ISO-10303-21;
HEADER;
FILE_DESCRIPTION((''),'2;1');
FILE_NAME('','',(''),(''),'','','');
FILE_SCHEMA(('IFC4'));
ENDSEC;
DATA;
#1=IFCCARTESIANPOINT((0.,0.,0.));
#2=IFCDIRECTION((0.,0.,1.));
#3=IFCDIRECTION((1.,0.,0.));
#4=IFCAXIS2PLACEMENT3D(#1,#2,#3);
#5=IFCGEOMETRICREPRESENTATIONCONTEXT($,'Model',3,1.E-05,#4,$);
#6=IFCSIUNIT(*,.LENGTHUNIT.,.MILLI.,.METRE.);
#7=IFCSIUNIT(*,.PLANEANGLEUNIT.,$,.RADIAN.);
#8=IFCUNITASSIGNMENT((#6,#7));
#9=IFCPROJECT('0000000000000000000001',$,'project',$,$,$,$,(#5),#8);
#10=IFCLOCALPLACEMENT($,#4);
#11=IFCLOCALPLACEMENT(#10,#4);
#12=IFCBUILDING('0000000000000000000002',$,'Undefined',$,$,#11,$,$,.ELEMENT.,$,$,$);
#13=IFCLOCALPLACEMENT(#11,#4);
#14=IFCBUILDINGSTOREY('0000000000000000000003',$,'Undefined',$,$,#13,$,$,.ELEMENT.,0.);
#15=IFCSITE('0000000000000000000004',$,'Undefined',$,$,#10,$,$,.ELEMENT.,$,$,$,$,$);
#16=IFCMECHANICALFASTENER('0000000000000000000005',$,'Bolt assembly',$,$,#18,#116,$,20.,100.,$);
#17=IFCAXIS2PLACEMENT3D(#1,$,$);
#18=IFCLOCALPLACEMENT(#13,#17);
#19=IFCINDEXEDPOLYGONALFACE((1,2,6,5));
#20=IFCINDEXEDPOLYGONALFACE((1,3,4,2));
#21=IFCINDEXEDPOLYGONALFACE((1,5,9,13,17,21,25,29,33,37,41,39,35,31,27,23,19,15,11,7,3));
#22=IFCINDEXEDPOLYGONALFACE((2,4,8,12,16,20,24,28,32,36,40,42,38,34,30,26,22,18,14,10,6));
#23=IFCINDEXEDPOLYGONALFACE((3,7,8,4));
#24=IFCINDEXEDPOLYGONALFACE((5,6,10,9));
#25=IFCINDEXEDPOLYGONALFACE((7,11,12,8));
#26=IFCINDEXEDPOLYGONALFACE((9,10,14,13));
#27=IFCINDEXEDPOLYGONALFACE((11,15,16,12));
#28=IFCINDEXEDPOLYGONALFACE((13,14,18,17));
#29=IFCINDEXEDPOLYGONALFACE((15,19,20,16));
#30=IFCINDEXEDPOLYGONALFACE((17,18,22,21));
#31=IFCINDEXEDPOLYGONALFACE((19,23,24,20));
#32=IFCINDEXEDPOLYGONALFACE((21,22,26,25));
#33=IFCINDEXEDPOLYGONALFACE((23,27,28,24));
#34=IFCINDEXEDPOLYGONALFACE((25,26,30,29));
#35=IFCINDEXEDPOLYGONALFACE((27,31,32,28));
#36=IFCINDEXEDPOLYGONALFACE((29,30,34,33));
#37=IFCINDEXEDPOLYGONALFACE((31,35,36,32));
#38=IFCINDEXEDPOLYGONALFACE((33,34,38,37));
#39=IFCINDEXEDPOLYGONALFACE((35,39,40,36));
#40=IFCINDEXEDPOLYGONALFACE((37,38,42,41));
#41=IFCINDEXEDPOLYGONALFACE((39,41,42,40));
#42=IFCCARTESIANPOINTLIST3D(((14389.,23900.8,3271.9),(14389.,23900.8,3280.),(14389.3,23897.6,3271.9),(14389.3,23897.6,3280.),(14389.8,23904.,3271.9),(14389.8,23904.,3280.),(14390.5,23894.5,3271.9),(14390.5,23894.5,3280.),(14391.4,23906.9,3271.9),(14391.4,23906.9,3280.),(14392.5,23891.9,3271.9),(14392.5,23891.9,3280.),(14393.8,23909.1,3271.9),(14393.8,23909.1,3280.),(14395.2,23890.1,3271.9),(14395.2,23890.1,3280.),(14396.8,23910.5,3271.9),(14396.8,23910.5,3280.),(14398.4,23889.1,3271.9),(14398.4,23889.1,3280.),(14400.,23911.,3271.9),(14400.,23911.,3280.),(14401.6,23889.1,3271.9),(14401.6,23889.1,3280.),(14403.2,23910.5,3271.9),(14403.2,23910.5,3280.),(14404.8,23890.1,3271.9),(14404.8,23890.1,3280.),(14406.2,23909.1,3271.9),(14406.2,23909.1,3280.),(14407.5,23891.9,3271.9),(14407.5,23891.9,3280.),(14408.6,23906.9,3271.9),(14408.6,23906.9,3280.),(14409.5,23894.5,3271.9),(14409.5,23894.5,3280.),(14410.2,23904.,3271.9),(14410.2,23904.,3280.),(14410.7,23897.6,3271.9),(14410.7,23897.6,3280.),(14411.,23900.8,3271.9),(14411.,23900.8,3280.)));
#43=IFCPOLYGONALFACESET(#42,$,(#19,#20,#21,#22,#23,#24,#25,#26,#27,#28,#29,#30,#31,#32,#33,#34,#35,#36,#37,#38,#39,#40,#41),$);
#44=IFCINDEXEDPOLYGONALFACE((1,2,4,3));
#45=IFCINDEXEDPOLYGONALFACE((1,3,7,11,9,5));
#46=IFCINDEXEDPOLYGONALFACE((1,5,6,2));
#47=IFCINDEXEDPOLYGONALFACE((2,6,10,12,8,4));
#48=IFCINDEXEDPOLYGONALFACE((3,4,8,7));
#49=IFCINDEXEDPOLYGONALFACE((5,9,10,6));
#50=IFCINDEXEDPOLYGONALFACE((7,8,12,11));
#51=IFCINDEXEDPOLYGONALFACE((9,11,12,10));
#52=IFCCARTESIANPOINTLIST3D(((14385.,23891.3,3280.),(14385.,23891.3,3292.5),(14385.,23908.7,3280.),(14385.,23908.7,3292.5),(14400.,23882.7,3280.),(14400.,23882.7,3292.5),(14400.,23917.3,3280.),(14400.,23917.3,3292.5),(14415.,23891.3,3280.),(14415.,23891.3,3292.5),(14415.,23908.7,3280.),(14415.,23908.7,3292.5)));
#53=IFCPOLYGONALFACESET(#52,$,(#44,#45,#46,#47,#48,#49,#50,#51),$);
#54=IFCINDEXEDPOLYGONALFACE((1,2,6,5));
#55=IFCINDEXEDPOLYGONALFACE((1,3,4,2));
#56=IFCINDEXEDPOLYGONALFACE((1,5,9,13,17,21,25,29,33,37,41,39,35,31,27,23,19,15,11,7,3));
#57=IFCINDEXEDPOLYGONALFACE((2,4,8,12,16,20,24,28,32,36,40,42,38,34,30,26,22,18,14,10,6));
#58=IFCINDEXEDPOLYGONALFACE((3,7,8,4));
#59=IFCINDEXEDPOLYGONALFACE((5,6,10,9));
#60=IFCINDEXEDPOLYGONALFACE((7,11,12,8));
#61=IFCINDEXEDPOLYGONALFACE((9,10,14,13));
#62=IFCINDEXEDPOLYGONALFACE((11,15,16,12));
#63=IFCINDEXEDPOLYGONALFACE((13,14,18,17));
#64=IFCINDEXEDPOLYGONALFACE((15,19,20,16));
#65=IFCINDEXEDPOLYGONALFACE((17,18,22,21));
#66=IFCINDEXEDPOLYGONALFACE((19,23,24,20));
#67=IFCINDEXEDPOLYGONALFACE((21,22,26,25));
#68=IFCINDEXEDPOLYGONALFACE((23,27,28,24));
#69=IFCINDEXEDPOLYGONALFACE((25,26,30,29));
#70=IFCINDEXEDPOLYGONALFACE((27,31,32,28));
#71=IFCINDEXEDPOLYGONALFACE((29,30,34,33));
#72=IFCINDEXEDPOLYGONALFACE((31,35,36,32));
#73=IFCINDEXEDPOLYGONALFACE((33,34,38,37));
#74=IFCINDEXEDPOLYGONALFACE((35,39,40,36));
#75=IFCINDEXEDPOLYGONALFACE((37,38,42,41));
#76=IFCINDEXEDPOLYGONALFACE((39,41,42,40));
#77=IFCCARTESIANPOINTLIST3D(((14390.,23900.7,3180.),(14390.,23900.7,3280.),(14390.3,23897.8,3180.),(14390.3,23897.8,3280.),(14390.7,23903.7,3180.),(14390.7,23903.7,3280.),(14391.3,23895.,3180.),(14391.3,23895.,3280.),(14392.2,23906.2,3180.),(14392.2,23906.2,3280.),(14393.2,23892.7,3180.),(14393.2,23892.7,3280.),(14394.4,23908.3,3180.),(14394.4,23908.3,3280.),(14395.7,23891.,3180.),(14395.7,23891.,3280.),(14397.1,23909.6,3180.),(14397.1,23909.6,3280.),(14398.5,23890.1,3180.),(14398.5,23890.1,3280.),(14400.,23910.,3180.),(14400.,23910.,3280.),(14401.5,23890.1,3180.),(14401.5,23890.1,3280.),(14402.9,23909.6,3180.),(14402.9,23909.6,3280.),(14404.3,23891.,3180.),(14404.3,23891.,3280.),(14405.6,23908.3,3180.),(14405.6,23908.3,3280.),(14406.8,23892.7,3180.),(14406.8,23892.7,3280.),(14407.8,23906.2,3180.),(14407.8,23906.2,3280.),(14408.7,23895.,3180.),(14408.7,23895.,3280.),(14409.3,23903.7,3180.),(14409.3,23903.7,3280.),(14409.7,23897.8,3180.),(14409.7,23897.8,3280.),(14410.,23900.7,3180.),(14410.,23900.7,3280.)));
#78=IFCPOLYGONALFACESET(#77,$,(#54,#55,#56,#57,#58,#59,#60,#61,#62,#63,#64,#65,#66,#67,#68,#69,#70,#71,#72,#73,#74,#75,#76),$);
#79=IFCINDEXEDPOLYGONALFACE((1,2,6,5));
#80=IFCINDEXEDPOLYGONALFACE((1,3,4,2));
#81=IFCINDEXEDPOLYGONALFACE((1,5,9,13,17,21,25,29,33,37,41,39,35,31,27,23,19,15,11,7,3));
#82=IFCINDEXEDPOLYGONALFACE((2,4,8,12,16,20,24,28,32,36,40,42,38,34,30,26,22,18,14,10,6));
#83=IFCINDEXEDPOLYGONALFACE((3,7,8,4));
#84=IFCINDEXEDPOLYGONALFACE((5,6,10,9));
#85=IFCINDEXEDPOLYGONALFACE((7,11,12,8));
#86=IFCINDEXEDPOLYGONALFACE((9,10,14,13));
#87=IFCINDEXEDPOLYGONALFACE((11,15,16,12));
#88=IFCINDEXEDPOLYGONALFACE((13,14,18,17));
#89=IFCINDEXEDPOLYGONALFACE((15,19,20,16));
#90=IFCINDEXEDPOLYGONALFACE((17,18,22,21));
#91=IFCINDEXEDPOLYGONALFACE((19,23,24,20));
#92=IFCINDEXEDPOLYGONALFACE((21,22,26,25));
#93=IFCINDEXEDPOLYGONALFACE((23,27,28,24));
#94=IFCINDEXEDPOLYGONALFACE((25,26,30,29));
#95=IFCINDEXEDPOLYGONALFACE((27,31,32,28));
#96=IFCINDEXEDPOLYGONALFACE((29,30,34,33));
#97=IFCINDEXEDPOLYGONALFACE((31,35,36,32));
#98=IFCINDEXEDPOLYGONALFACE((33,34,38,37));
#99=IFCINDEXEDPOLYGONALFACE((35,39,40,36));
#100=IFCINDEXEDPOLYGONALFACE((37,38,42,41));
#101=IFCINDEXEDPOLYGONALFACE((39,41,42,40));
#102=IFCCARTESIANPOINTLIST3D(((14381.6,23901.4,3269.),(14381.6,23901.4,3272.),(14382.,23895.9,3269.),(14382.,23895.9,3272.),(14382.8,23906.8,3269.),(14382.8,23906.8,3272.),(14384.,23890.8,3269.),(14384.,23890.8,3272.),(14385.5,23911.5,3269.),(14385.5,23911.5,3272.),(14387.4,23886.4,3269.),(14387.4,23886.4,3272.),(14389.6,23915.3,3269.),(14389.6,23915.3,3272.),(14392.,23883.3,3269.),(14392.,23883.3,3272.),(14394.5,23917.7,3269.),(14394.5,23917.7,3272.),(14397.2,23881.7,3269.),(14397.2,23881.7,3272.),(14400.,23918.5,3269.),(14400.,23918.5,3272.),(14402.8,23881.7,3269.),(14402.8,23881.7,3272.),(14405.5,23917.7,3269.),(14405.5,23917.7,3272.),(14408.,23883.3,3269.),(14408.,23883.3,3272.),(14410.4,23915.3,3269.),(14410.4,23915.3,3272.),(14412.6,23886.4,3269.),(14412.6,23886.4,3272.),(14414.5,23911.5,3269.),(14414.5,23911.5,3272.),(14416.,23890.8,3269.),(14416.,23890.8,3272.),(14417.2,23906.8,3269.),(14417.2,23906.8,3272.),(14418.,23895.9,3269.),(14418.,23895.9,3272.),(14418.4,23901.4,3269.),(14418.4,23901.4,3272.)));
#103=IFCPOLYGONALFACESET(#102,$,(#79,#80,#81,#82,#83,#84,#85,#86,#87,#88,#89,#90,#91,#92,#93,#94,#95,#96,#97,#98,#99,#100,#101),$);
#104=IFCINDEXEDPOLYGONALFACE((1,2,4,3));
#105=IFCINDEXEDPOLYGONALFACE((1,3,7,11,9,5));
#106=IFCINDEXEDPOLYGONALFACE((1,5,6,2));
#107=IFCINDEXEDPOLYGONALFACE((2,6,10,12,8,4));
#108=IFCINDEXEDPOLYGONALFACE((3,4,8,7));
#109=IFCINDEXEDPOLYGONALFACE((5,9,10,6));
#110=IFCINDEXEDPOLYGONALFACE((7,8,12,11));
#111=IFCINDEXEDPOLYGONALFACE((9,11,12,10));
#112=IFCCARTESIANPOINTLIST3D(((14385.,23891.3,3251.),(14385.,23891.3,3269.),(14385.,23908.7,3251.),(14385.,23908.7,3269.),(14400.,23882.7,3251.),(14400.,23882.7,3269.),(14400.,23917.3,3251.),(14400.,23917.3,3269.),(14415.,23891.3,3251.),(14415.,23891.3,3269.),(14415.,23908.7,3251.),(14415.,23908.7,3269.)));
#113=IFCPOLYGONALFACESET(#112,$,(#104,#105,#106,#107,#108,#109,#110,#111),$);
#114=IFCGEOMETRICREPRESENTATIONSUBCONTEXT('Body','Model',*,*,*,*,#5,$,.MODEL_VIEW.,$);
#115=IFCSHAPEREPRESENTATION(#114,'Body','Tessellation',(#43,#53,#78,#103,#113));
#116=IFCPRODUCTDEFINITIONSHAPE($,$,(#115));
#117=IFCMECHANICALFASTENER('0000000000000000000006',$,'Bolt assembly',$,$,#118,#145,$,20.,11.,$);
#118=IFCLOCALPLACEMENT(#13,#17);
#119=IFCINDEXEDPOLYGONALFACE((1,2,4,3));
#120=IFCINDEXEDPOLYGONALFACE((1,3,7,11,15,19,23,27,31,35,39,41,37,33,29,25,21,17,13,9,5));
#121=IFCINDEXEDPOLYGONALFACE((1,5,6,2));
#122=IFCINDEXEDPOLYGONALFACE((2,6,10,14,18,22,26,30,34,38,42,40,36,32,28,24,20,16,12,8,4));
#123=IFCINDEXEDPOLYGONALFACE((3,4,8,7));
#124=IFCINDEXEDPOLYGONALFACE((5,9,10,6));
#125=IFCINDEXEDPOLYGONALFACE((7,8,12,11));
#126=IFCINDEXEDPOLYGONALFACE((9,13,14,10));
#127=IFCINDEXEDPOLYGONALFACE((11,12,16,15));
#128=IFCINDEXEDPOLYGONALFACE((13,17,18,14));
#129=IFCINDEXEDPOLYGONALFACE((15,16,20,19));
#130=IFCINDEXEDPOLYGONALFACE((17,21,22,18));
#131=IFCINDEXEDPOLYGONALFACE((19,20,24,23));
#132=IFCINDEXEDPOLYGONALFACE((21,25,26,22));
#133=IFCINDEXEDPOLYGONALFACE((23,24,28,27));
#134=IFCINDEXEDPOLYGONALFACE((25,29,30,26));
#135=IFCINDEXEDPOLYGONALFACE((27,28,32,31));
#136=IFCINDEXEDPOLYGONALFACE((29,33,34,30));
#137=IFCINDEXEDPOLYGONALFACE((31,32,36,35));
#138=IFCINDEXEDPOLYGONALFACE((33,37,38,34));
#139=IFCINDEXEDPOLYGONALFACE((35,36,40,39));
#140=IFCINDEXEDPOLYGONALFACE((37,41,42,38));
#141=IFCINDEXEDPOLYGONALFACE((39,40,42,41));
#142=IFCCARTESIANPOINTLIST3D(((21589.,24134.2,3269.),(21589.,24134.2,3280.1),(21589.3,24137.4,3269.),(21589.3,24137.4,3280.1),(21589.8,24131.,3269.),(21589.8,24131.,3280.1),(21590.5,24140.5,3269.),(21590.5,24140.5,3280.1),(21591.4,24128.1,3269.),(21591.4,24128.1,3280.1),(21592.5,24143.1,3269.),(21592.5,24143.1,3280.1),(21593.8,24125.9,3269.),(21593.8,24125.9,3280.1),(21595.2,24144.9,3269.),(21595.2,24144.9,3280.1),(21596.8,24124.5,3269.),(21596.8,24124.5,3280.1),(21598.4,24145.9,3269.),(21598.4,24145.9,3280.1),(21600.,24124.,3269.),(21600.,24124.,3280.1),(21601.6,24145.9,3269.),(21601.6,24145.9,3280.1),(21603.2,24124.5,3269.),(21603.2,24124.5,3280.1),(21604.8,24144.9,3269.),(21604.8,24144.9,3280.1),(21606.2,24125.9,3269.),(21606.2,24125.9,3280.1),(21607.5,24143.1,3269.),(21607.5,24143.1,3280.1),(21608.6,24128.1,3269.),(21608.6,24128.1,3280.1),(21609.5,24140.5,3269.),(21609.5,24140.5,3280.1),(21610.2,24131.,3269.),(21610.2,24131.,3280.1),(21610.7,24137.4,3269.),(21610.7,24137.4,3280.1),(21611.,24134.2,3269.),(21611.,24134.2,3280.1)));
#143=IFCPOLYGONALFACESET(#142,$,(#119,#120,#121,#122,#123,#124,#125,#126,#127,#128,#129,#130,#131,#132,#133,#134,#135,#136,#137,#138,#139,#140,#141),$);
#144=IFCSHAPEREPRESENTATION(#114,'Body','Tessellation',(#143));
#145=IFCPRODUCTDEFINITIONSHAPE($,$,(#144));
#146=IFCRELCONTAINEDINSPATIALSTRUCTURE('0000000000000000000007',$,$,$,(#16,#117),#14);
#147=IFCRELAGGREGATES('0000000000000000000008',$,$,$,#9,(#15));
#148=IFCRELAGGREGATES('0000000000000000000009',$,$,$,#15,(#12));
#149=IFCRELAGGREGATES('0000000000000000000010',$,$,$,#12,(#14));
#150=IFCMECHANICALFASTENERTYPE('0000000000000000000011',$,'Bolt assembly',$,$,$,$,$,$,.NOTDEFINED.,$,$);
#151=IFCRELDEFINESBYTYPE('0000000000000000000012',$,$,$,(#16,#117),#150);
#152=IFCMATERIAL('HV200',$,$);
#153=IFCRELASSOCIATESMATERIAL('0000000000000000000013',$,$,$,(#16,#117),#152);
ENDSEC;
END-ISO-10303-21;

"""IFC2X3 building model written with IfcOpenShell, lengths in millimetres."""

from ifc_helpers import new_model, si_unit, frame, origin_with_axes, origin_2d_with_axis, place, context, subcontext, project, spatial, polyline, circle, outline, extrude, source, transform, mapped, material, type_object, element, save


model = new_model("IFC2X3")

# Units and contexts
model_context = context("Model", 3, precision=1e-05, world=origin_with_axes())
body_context = subcontext(model_context, "Body", "Model", "MODEL_VIEW")
ifc_project = project(units=[si_unit("LENGTHUNIT", "METRE", prefix="MILLI"), si_unit("PLANEANGLEUNIT", "RADIAN")], contexts=[model_context])

# Site, building, storey
site_placement = place(None, origin_with_axes())
site = spatial("IfcSite", under=ifc_project, at=site_placement, Name="Undefined", CompositionType="ELEMENT")
building_placement = place(site_placement, origin_with_axes())
building = spatial("IfcBuilding", under=site, at=building_placement, Name="Undefined", CompositionType="ELEMENT")
storey_placement = place(building_placement, origin_with_axes())
storey = spatial("IfcBuildingStorey", under=building, at=storey_placement, Name="Undefined", CompositionType="ELEMENT", Elevation=0.0)

# Mechanical fasteners
ifc_material_1 = material(Name="HV200")
mechanical_fastener_type = type_object("IfcMechanicalFastenerType", Name="Bolt assembly")
shared_shape_1 = source(origin_with_axes(), body_context, "Body", "SweptSolid", [
    extrude(circle(Radius=11.0, at=origin_2d_with_axis()), frame((0.0, 0.0, 0.0), z_axis=(0.0, 1.0, 0.0), x_axis=(1.0, 0.0, 0.0)), (0.0, 0.0, 1.0), 8.1),
    extrude(outline(polyline([(17.3, 0.0), (8.7, 15.0), (-8.7, 15.0), (-17.3, 0.0), (-8.7, -15.0), (8.7, -15.0), (17.3, 0.0)])), frame((0.0, -12.5, 0.0), z_axis=(0.0, 1.0, 0.0), x_axis=(1.0, 0.0, 0.0)), (0.0, 0.0, 1.0), 12.5),
    extrude(circle(Radius=10.0, at=origin_2d_with_axis()), frame((0.0, 0.0, 0.0), z_axis=(0.0, 1.0, 0.0), x_axis=(1.0, 0.0, 0.0)), (0.0, 0.0, 1.0), 100.0),
    extrude(circle(Radius=18.5, at=origin_2d_with_axis()), frame((0.0, 8.0, 0.0), z_axis=(0.0, 1.0, 0.0), x_axis=(1.0, 0.0, 0.0)), (0.0, 0.0, 1.0), 3.0),
    extrude(outline(polyline([(17.3, 0.0), (8.7, 15.0), (-8.7, 15.0), (-17.3, 0.0), (-8.7, -15.0), (8.7, -15.0), (17.3, 0.0)])), frame((0.0, 11.0, 0.0), z_axis=(0.0, 1.0, 0.0), x_axis=(1.0, 0.0, 0.0)), (0.0, 0.0, 1.0), 18.0),
])
mechanical_fastener_1_placement = place(storey_placement, frame((14400.0, 23900.0, 3280.0), z_axis=(-1.0, 0.0, 0.0), x_axis=(0.0, 1.0, 0.0)))
element("IfcMechanicalFastener", 1, at=mechanical_fastener_1_placement, inside=storey, type_object=mechanical_fastener_type, material=ifc_material_1, Name="Bolt assembly", NominalDiameter=20.0, NominalLength=100.0, context=body_context, shape_type="MappedRepresentation", body=[
    mapped(shared_shape_1, transform((0.0, 0.0, 0.0))),
])
shared_shape_2 = source(origin_with_axes(), body_context, "Body", "SweptSolid", [
    extrude(circle(Radius=11.0, at=origin_2d_with_axis()), frame((0.0, -11.0, 0.0), z_axis=(0.0, 1.0, 0.0), x_axis=(1.0, 0.0, 0.0)), (0.0, 0.0, 1.0), 11.1),
])
mechanical_fastener_2_placement = place(storey_placement, frame((21600.0, 24135.0, 3280.0), z_axis=(-1.0, 0.0, 0.0), x_axis=(0.0, -1.0, 0.0)))
element("IfcMechanicalFastener", 2, at=mechanical_fastener_2_placement, inside=storey, type_object=mechanical_fastener_type, material=ifc_material_1, Name="Bolt assembly", NominalDiameter=20.0, NominalLength=11.0, context=body_context, shape_type="MappedRepresentation", body=[
    mapped(shared_shape_2, transform((0.0, 0.0, 0.0))),
])

save(model, "model.ifc")
